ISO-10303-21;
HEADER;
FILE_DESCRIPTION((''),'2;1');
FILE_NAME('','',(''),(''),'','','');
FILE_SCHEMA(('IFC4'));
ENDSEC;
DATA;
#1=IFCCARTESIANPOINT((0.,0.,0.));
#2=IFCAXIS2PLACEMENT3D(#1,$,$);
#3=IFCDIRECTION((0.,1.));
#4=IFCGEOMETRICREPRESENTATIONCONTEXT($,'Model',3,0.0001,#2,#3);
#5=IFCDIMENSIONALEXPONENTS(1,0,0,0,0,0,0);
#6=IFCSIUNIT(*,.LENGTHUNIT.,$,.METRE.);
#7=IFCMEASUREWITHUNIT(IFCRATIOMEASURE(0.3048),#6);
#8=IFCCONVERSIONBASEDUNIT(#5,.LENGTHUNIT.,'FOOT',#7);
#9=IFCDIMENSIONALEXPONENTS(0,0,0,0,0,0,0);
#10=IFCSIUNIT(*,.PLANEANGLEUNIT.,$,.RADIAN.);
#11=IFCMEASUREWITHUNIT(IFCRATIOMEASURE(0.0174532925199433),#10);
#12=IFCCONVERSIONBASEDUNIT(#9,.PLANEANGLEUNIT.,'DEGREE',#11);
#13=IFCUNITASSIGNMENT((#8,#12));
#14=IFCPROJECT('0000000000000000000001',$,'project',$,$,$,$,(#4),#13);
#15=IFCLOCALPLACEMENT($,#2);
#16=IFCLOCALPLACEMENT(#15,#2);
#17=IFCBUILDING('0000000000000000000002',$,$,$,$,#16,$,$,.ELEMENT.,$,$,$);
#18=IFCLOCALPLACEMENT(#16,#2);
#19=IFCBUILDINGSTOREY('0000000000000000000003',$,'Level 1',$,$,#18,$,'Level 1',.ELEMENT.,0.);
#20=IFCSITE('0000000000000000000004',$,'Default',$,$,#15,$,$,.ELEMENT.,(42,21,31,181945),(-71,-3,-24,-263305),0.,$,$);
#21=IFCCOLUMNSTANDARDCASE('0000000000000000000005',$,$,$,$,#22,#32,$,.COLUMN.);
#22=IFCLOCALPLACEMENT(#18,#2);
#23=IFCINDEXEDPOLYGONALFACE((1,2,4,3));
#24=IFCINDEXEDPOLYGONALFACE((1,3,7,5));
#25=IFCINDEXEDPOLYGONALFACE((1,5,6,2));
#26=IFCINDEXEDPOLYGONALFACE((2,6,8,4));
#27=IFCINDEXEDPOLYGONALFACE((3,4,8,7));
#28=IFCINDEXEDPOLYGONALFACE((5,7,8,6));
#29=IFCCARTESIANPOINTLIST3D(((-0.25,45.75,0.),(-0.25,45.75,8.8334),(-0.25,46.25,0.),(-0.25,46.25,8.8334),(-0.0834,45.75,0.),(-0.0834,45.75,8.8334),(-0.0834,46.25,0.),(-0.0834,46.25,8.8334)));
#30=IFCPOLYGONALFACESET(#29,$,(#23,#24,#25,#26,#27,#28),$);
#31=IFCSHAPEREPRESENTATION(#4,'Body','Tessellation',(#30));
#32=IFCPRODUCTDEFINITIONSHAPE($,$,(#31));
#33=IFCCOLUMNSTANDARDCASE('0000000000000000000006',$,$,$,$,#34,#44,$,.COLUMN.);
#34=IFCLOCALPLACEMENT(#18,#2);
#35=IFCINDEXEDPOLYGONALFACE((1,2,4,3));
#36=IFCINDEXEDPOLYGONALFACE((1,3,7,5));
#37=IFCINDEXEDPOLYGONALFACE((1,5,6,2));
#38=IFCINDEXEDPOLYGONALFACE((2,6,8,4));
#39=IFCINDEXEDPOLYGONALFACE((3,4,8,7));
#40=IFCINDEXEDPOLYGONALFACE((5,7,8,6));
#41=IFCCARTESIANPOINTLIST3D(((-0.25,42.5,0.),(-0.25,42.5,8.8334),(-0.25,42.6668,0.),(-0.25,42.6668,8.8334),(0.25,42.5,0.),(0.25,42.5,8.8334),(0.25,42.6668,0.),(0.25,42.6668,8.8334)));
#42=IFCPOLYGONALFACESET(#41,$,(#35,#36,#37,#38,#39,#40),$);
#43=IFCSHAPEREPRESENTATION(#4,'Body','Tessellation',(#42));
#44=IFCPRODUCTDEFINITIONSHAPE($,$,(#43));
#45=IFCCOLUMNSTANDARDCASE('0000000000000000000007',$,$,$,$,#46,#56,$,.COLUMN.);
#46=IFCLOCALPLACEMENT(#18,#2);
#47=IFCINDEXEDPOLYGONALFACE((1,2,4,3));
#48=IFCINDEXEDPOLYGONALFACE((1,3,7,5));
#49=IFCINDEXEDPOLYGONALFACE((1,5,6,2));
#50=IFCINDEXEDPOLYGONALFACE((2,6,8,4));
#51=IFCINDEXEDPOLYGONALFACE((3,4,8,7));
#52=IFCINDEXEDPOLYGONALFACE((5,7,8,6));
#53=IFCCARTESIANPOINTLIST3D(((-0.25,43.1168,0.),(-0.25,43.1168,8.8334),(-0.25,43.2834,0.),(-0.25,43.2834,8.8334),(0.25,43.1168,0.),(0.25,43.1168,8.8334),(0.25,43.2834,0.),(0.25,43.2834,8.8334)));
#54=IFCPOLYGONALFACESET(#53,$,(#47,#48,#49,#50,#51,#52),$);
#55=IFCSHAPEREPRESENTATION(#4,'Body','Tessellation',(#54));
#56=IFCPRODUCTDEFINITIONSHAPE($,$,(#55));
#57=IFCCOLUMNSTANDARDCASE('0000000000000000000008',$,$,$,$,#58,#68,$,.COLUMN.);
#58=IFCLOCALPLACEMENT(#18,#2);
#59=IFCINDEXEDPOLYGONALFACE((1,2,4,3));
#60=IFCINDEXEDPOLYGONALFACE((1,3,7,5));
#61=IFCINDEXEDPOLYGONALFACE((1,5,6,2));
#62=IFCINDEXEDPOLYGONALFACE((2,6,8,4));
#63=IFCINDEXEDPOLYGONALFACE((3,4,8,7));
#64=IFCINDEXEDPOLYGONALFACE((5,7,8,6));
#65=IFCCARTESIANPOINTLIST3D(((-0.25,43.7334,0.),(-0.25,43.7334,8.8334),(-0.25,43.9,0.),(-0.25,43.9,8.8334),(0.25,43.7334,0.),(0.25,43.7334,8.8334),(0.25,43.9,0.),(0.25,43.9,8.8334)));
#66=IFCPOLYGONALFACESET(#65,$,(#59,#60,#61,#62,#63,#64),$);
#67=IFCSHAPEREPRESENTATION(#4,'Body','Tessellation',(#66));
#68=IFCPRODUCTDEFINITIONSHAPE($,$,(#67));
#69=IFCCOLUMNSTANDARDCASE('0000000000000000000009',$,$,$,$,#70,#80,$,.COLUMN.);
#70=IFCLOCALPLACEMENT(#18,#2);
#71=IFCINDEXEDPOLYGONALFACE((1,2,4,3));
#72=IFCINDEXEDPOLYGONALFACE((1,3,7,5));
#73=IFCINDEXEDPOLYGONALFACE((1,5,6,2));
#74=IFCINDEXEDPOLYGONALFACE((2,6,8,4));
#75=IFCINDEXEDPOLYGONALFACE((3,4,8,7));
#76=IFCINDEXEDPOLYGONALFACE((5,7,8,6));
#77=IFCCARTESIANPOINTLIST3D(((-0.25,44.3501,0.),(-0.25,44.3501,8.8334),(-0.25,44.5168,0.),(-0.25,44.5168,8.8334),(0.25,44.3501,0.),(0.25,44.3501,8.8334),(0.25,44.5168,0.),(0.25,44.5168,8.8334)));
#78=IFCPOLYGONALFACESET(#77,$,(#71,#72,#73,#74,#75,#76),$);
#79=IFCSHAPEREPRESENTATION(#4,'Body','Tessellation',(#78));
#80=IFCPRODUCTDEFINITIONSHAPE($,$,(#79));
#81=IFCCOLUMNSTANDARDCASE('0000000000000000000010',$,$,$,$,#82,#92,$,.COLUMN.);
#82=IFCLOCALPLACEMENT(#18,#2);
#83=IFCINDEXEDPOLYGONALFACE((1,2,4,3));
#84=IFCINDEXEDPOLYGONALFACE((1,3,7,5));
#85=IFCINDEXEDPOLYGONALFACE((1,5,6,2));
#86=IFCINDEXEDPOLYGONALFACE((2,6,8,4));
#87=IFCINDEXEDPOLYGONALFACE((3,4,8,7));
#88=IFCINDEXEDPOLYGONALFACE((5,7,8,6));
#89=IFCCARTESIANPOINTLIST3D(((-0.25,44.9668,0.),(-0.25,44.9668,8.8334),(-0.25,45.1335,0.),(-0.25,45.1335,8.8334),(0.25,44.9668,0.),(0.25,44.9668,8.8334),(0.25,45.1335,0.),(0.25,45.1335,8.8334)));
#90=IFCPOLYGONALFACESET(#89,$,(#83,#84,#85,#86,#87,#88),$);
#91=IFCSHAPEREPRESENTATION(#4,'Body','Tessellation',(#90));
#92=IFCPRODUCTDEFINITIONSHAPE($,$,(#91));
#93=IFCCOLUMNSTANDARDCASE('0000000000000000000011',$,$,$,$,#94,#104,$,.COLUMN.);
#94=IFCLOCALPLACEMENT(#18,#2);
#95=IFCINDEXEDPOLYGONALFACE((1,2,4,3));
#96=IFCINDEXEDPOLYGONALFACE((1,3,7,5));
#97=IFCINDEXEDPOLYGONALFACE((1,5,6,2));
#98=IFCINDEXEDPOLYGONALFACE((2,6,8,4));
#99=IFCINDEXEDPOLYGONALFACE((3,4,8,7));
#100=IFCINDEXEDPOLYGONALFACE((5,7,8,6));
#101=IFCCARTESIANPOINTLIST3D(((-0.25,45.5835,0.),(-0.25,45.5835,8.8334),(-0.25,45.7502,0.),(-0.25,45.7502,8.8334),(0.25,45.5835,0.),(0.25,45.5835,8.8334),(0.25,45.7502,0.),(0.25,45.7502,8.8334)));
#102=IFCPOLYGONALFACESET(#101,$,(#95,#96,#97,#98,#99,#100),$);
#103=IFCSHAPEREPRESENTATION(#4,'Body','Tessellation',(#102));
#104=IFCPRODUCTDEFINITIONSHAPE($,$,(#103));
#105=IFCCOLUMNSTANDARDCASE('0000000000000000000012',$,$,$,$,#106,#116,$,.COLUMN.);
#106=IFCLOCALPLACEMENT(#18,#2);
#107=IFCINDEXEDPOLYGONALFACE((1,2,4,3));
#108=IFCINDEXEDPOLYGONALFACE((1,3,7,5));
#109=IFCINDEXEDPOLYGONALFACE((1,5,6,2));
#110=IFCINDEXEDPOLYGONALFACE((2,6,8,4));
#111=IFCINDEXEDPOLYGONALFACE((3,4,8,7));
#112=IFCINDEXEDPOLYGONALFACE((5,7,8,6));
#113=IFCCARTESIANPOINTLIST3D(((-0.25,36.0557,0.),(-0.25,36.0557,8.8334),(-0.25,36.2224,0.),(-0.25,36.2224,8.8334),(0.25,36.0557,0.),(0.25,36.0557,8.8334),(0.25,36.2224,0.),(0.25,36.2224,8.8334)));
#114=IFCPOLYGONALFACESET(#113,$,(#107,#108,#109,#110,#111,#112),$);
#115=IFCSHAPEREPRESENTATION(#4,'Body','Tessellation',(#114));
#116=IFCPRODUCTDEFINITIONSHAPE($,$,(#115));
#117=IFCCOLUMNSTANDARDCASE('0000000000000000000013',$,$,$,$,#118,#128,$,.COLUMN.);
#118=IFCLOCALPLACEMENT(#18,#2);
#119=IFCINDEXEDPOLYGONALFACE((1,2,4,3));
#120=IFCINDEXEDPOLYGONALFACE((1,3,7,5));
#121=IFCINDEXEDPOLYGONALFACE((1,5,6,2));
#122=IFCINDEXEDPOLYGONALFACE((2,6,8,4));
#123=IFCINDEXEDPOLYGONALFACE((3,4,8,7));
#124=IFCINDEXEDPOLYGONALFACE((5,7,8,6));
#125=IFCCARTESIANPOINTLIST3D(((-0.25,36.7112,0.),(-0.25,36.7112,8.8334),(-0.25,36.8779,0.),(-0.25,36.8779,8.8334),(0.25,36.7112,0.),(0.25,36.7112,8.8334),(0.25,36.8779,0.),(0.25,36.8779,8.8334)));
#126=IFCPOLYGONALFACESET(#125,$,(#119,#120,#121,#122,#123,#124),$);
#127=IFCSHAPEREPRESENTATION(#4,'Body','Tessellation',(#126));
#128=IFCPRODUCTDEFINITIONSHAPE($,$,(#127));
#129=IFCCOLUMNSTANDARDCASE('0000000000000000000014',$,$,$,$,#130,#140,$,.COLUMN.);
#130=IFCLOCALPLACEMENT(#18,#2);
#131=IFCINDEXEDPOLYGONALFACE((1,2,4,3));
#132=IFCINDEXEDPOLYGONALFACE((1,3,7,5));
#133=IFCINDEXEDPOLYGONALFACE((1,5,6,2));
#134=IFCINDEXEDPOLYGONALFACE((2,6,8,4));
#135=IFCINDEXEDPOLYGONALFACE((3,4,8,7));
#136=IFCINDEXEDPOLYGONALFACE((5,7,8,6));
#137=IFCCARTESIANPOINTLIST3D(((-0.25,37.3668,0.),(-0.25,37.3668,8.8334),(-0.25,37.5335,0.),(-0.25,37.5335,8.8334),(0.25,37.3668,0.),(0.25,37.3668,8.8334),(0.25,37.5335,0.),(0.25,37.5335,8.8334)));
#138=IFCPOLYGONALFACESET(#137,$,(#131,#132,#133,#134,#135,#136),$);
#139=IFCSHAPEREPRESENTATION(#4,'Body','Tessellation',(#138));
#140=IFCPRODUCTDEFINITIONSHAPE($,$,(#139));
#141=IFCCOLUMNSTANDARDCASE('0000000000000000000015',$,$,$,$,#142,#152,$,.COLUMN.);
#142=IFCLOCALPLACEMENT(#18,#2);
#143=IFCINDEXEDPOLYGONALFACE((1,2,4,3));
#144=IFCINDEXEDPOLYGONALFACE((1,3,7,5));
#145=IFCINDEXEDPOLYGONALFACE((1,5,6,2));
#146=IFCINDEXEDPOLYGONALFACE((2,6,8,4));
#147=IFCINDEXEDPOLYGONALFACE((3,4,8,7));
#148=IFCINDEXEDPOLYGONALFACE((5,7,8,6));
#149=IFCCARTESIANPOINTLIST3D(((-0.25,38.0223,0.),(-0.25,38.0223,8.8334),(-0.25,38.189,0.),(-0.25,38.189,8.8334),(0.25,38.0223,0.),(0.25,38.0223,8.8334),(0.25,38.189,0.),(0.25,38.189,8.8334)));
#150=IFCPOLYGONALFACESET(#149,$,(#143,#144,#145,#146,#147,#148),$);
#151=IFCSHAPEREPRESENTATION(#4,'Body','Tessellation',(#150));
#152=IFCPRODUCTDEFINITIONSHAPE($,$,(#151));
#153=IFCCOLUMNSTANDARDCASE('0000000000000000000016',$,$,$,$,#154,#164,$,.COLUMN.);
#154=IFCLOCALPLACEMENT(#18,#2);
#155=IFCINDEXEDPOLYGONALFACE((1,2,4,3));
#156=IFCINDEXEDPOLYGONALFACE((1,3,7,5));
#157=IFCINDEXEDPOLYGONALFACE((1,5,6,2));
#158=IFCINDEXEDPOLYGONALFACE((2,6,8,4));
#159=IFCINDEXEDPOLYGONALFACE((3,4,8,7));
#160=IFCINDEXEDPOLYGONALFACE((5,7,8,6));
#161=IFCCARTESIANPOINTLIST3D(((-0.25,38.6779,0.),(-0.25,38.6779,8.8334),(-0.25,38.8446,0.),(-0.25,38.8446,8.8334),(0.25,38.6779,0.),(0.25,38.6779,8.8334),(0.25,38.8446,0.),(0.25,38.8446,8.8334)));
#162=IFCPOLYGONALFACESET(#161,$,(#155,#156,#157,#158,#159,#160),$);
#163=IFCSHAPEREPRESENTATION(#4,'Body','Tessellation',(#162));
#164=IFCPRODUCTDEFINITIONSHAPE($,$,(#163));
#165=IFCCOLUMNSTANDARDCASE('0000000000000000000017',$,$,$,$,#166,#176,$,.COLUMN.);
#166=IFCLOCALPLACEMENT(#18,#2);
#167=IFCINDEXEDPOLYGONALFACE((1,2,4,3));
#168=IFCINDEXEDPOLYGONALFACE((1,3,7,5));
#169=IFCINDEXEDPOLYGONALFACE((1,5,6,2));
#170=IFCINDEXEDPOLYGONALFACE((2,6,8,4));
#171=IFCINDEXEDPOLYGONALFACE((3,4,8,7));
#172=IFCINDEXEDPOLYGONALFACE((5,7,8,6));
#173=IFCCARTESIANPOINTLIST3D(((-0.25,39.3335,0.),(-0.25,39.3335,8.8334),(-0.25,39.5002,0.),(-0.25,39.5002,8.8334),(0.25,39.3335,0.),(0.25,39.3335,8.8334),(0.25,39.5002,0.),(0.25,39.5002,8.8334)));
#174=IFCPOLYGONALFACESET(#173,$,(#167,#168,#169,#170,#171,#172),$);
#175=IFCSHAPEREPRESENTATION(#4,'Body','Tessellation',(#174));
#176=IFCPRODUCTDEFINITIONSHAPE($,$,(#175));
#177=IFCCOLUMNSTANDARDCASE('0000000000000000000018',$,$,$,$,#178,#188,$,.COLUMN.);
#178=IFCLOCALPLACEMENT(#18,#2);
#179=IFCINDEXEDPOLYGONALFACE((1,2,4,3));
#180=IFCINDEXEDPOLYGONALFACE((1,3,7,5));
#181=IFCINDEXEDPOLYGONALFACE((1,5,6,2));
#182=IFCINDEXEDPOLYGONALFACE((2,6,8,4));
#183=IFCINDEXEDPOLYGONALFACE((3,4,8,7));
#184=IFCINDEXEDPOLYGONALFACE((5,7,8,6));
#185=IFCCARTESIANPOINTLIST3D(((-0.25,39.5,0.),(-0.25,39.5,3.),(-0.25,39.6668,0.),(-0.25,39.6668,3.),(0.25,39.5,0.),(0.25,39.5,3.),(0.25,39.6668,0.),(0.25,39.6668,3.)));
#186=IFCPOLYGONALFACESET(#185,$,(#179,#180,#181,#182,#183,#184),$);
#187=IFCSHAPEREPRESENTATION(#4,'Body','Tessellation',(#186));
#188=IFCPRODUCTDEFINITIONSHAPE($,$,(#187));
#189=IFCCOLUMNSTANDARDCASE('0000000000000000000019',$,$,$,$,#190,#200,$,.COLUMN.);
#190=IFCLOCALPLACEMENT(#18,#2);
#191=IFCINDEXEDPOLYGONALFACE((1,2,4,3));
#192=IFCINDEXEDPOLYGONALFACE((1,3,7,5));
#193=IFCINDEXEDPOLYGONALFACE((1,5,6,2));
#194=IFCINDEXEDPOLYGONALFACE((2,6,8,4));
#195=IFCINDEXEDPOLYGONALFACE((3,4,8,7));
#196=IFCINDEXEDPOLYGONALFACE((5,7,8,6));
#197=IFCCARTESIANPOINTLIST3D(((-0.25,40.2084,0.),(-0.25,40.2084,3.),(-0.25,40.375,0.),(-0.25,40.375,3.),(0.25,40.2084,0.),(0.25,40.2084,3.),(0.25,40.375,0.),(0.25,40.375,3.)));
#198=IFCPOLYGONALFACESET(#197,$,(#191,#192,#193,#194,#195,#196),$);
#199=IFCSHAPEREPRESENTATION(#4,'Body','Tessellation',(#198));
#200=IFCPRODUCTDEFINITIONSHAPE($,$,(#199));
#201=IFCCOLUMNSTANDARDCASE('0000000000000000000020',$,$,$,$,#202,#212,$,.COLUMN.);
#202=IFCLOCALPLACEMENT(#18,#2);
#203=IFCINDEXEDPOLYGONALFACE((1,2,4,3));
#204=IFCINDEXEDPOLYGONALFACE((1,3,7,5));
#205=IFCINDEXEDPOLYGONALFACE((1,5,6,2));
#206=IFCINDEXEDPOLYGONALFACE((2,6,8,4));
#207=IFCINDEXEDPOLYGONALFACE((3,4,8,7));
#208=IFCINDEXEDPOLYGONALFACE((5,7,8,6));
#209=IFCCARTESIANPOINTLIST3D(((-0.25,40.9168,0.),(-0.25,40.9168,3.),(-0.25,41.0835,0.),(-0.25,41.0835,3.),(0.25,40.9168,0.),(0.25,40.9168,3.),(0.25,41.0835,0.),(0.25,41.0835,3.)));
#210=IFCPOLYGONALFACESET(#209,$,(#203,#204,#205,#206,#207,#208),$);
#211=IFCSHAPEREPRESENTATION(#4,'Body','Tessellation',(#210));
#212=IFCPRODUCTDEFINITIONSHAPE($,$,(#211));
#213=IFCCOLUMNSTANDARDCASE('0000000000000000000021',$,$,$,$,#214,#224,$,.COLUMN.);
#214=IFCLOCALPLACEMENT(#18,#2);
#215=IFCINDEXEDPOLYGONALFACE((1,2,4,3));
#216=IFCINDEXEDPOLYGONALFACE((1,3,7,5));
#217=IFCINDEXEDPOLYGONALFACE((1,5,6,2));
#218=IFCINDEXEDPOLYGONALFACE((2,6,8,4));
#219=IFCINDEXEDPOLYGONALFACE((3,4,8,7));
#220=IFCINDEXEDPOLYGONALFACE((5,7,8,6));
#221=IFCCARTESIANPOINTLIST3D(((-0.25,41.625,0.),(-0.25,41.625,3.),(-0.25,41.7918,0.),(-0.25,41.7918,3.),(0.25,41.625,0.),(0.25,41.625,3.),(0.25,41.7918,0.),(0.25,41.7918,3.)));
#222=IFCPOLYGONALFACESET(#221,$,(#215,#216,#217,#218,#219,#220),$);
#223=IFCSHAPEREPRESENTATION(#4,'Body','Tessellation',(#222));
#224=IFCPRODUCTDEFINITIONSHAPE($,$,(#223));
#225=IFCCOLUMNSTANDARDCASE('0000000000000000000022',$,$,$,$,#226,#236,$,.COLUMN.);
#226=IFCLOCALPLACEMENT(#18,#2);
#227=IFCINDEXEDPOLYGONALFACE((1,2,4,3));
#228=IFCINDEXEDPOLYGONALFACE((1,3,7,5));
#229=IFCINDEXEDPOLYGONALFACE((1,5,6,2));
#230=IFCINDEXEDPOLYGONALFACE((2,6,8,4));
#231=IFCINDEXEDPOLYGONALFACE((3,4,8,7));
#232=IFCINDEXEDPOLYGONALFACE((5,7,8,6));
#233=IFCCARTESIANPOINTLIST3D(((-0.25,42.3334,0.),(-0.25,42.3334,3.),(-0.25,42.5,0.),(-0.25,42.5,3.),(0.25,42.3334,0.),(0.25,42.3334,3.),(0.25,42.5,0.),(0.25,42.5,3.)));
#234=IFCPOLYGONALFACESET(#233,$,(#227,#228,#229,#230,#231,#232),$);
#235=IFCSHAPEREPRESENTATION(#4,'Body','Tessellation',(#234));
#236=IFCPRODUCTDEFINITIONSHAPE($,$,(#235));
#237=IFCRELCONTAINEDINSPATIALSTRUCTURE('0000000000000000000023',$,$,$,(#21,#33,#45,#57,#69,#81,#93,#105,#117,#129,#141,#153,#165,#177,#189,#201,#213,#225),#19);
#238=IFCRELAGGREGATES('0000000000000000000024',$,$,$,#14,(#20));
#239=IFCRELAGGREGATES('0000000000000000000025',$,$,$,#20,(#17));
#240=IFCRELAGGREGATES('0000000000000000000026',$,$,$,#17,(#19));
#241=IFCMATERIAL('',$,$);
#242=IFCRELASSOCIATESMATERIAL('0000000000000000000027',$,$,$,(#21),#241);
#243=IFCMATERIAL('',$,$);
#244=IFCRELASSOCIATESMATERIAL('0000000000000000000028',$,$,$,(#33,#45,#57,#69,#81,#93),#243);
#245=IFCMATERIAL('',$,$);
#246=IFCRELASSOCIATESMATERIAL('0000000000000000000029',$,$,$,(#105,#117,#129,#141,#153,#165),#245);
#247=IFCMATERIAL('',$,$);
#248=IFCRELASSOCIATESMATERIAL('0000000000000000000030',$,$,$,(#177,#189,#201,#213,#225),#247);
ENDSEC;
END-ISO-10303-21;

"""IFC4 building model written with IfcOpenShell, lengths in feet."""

from ifc_helpers import new_model, entity, si_unit, converted_unit, direction, frame, origin, place, context, project, spatial, rectangle, extrude, material, element, save


model = new_model("IFC4")

# Units and contexts
model_context = context("Model", 3, precision=0.0001, world=origin(), true_north=direction((0.0, 1.0)))
ifc_project = project(units=[converted_unit("LENGTHUNIT", "FOOT", entity("IfcRatioMeasure", 0.3048), si_unit("LENGTHUNIT", "METRE"), dimensions=[1, 0, 0, 0, 0, 0, 0]), converted_unit("PLANEANGLEUNIT", "DEGREE", entity("IfcRatioMeasure", 0.0174532925199433), si_unit("PLANEANGLEUNIT", "RADIAN"), dimensions=[0, 0, 0, 0, 0, 0, 0])], contexts=[model_context])

# Site, building, storey
site_placement = place(None, origin())
site = spatial("IfcSite", under=ifc_project, at=site_placement, Name="Default", CompositionType="ELEMENT", RefLatitude=(42, 21, 31, 181945), RefLongitude=(-71, -3, -24, -263305), RefElevation=0.0)
building_placement = place(site_placement, origin())
building = spatial("IfcBuilding", under=site, at=building_placement, CompositionType="ELEMENT")
storey_placement = place(building_placement, origin())
storey = spatial("IfcBuildingStorey", under=building, at=storey_placement, Name="Level 1", LongName="Level 1", CompositionType="ELEMENT", Elevation=0.0)

# Columns
ifc_material_1 = material(Name="")
placement_1 = place(storey_placement, frame((-0.25, 46.0, 0.0)))
column_placement = place(placement_1, frame((0.0833, 0.0, 0.0), z_axis=(0.0, 0.0, 1.0), x_axis=(1.0, 0.0, 0.0)))
element("IfcColumnStandardCase", 1, at=column_placement, inside=storey, material=ifc_material_1, PredefinedType="COLUMN", context=model_context, shape_type="SweptSolid", body=[
    extrude(rectangle(XDim=0.1667, YDim=0.5), origin(), (0.0, 0.0, 1.0), 8.8334),
])
ifc_material_2 = material(Name="")
placement_2 = place(storey_placement, frame((0.0, -0.25, 0.0), z_axis=(0.0, 0.0, 1.0), x_axis=(0.0, 1.0, 0.0)))
for number, where, z_axis, x_axis in (
    (2, (42.8334, 0.0, 0.0), (0.0, 0.0, 1.0), (1.0, 0.0, 0.0)),
    (3, (43.4501, 0.0, 0.0), (0.0, 0.0, 1.0), (1.0, 0.0, 0.0)),
    (4, (44.0667, 0.0, 0.0), (0.0, 0.0, 1.0), (1.0, 0.0, 0.0)),
    (5, (44.6834, 0.0, 0.0), (0.0, 0.0, 1.0), (1.0, 0.0, 0.0)),
    (6, (45.3001, 0.0, 0.0), (0.0, 0.0, 1.0), (1.0, 0.0, 0.0)),
    (7, (45.9168, 0.0, 0.0), (0.0, 0.0, 1.0), (1.0, 0.0, 0.0)),
):
    element("IfcColumnStandardCase", number, at=place(placement_2, frame(where, z_axis=z_axis, x_axis=x_axis)), inside=storey, material=ifc_material_2, PredefinedType="COLUMN", context=model_context, shape_type="SweptSolid", body=[
        extrude(rectangle(XDim=0.1667, YDim=0.5), origin(), (0.0, 0.0, 1.0), 8.8334),
    ])
ifc_material_3 = material(Name="")
for number, where, z_axis, x_axis in (
    (8, (36.389, 0.0, 0.0), (0.0, 0.0, 1.0), (1.0, 0.0, 0.0)),
    (9, (37.0445, 0.0, 0.0), (0.0, 0.0, 1.0), (1.0, 0.0, 0.0)),
    (10, (37.7001, 0.0, 0.0), (0.0, 0.0, 1.0), (1.0, 0.0, 0.0)),
    (11, (38.3556, 0.0, 0.0), (0.0, 0.0, 1.0), (1.0, 0.0, 0.0)),
    (12, (39.0112, 0.0, 0.0), (0.0, 0.0, 1.0), (1.0, 0.0, 0.0)),
    (13, (39.6668, 0.0, 0.0), (0.0, 0.0, 1.0), (1.0, 0.0, 0.0)),
):
    element("IfcColumnStandardCase", number, at=place(placement_2, frame(where, z_axis=z_axis, x_axis=x_axis)), inside=storey, material=ifc_material_3, PredefinedType="COLUMN", context=model_context, shape_type="SweptSolid", body=[
        extrude(rectangle(XDim=0.1667, YDim=0.5), origin(), (0.0, 0.0, 1.0), 8.8334),
    ])
ifc_material_4 = material(Name="")
for number, where, z_axis, x_axis in (
    (14, (39.8334, 0.0, 0.0), (0.0, 0.0, 1.0), (1.0, 0.0, 0.0)),
    (15, (40.5417, 0.0, 0.0), (0.0, 0.0, 1.0), (1.0, 0.0, 0.0)),
    (16, (41.2501, 0.0, 0.0), (0.0, 0.0, 1.0), (1.0, 0.0, 0.0)),
    (17, (41.9584, 0.0, 0.0), (0.0, 0.0, 1.0), (1.0, 0.0, 0.0)),
    (18, (42.6667, 0.0, 0.0), (0.0, 0.0, 1.0), (1.0, 0.0, 0.0)),
):
    element("IfcColumnStandardCase", number, at=place(placement_2, frame(where, z_axis=z_axis, x_axis=x_axis)), inside=storey, material=ifc_material_4, PredefinedType="COLUMN", context=model_context, shape_type="SweptSolid", body=[
        extrude(rectangle(XDim=0.1667, YDim=0.5), origin(), (0.0, 0.0, 1.0), 3.0),
    ])

save(model, "model.ifc")
